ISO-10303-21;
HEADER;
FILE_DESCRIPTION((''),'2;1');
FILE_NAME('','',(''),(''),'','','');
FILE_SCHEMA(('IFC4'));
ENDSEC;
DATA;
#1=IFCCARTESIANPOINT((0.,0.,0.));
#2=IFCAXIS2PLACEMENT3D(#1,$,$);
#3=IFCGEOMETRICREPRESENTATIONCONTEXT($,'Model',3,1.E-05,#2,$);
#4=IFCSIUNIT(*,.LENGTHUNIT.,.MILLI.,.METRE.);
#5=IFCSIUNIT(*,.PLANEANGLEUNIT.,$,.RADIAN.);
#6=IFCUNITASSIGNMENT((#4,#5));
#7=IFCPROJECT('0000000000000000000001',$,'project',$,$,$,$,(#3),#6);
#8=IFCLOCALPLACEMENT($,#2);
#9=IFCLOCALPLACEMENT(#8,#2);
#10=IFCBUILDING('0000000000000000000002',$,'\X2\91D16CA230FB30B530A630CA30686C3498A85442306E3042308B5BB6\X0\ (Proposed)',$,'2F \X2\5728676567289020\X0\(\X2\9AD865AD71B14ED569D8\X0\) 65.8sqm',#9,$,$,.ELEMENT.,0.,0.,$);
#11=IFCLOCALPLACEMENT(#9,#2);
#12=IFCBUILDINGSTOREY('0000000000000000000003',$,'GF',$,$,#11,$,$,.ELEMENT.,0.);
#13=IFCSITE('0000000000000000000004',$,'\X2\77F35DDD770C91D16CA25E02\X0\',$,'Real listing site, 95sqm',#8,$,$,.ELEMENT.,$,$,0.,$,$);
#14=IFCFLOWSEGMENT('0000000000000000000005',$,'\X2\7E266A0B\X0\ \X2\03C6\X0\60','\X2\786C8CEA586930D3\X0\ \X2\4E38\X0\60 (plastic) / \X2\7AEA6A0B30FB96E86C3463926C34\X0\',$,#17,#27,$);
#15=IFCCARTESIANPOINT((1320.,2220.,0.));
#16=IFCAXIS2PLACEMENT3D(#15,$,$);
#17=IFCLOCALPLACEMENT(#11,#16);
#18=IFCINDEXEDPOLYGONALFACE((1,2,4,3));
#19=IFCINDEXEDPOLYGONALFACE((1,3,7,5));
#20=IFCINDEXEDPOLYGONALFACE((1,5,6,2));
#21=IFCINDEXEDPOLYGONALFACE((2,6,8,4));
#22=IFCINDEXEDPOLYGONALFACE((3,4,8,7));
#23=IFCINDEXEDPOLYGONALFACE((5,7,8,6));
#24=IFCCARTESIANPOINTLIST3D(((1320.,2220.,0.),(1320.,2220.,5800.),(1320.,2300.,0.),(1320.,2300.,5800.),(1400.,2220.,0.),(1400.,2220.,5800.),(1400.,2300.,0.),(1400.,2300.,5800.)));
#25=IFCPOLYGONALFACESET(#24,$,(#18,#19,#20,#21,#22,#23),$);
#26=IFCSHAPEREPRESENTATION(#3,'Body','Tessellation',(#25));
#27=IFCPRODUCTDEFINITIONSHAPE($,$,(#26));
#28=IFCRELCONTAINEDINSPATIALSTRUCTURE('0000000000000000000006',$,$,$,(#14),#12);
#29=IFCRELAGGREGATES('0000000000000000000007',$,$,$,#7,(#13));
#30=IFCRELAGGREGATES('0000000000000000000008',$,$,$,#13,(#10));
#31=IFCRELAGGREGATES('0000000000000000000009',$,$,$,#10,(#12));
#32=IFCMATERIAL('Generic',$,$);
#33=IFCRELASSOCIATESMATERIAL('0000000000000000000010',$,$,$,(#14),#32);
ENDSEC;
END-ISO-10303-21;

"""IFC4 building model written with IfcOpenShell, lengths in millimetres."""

from ifc_helpers import new_model, si_unit, frame, frame_2d, origin, place, context, project, spatial, rectangle, extrude, material, element, save


model = new_model("IFC4")

# Units and contexts
model_context = context("Model", 3, precision=1e-05, world=origin())
ifc_project = project(units=[si_unit("LENGTHUNIT", "METRE", prefix="MILLI"), si_unit("PLANEANGLEUNIT", "RADIAN")], contexts=[model_context])

# Site, building, storey
site_placement = place(None, origin())
site = spatial("IfcSite", under=ifc_project, at=site_placement, Name="石川県金沢市", ObjectType="Real listing site, 95sqm", CompositionType="ELEMENT", RefElevation=0.0)
building_placement = place(site_placement, origin())
building = spatial("IfcBuilding", under=site, at=building_placement, Name="金沢・サウナと水風呂のある家 (Proposed)", ObjectType="2F 在来木造(高断熱仕様) 65.8sqm", CompositionType="ELEMENT", ElevationOfRefHeight=0.0, ElevationOfTerrain=0.0)
storey_placement = place(building_placement, origin())
storey = spatial("IfcBuildingStorey", under=building, at=storey_placement, Name="GF", CompositionType="ELEMENT", Elevation=0.0)

# Shared definitions
ifc_material_1 = material(Name="Generic")

# Flow segment
flow_segment_1_placement = place(storey_placement, frame((1320.0, 2220.0, 0.0)))
element("IfcFlowSegment", 1, at=flow_segment_1_placement, inside=storey, material=ifc_material_1, Name="縦樋 φ60", Description="硬質塩ビ 丸60 (plastic) / 竪樋・雨水排水", context=model_context, shape_type="SweptSolid", body=[
    extrude(rectangle(XDim=80.0, YDim=80.0, at=frame_2d((40.0, 40.0))), frame((1320.0, 2220.0, 0.0)), (0.0, 0.0, 1.0), 5800.0),
])

save(model, "model.ifc")
